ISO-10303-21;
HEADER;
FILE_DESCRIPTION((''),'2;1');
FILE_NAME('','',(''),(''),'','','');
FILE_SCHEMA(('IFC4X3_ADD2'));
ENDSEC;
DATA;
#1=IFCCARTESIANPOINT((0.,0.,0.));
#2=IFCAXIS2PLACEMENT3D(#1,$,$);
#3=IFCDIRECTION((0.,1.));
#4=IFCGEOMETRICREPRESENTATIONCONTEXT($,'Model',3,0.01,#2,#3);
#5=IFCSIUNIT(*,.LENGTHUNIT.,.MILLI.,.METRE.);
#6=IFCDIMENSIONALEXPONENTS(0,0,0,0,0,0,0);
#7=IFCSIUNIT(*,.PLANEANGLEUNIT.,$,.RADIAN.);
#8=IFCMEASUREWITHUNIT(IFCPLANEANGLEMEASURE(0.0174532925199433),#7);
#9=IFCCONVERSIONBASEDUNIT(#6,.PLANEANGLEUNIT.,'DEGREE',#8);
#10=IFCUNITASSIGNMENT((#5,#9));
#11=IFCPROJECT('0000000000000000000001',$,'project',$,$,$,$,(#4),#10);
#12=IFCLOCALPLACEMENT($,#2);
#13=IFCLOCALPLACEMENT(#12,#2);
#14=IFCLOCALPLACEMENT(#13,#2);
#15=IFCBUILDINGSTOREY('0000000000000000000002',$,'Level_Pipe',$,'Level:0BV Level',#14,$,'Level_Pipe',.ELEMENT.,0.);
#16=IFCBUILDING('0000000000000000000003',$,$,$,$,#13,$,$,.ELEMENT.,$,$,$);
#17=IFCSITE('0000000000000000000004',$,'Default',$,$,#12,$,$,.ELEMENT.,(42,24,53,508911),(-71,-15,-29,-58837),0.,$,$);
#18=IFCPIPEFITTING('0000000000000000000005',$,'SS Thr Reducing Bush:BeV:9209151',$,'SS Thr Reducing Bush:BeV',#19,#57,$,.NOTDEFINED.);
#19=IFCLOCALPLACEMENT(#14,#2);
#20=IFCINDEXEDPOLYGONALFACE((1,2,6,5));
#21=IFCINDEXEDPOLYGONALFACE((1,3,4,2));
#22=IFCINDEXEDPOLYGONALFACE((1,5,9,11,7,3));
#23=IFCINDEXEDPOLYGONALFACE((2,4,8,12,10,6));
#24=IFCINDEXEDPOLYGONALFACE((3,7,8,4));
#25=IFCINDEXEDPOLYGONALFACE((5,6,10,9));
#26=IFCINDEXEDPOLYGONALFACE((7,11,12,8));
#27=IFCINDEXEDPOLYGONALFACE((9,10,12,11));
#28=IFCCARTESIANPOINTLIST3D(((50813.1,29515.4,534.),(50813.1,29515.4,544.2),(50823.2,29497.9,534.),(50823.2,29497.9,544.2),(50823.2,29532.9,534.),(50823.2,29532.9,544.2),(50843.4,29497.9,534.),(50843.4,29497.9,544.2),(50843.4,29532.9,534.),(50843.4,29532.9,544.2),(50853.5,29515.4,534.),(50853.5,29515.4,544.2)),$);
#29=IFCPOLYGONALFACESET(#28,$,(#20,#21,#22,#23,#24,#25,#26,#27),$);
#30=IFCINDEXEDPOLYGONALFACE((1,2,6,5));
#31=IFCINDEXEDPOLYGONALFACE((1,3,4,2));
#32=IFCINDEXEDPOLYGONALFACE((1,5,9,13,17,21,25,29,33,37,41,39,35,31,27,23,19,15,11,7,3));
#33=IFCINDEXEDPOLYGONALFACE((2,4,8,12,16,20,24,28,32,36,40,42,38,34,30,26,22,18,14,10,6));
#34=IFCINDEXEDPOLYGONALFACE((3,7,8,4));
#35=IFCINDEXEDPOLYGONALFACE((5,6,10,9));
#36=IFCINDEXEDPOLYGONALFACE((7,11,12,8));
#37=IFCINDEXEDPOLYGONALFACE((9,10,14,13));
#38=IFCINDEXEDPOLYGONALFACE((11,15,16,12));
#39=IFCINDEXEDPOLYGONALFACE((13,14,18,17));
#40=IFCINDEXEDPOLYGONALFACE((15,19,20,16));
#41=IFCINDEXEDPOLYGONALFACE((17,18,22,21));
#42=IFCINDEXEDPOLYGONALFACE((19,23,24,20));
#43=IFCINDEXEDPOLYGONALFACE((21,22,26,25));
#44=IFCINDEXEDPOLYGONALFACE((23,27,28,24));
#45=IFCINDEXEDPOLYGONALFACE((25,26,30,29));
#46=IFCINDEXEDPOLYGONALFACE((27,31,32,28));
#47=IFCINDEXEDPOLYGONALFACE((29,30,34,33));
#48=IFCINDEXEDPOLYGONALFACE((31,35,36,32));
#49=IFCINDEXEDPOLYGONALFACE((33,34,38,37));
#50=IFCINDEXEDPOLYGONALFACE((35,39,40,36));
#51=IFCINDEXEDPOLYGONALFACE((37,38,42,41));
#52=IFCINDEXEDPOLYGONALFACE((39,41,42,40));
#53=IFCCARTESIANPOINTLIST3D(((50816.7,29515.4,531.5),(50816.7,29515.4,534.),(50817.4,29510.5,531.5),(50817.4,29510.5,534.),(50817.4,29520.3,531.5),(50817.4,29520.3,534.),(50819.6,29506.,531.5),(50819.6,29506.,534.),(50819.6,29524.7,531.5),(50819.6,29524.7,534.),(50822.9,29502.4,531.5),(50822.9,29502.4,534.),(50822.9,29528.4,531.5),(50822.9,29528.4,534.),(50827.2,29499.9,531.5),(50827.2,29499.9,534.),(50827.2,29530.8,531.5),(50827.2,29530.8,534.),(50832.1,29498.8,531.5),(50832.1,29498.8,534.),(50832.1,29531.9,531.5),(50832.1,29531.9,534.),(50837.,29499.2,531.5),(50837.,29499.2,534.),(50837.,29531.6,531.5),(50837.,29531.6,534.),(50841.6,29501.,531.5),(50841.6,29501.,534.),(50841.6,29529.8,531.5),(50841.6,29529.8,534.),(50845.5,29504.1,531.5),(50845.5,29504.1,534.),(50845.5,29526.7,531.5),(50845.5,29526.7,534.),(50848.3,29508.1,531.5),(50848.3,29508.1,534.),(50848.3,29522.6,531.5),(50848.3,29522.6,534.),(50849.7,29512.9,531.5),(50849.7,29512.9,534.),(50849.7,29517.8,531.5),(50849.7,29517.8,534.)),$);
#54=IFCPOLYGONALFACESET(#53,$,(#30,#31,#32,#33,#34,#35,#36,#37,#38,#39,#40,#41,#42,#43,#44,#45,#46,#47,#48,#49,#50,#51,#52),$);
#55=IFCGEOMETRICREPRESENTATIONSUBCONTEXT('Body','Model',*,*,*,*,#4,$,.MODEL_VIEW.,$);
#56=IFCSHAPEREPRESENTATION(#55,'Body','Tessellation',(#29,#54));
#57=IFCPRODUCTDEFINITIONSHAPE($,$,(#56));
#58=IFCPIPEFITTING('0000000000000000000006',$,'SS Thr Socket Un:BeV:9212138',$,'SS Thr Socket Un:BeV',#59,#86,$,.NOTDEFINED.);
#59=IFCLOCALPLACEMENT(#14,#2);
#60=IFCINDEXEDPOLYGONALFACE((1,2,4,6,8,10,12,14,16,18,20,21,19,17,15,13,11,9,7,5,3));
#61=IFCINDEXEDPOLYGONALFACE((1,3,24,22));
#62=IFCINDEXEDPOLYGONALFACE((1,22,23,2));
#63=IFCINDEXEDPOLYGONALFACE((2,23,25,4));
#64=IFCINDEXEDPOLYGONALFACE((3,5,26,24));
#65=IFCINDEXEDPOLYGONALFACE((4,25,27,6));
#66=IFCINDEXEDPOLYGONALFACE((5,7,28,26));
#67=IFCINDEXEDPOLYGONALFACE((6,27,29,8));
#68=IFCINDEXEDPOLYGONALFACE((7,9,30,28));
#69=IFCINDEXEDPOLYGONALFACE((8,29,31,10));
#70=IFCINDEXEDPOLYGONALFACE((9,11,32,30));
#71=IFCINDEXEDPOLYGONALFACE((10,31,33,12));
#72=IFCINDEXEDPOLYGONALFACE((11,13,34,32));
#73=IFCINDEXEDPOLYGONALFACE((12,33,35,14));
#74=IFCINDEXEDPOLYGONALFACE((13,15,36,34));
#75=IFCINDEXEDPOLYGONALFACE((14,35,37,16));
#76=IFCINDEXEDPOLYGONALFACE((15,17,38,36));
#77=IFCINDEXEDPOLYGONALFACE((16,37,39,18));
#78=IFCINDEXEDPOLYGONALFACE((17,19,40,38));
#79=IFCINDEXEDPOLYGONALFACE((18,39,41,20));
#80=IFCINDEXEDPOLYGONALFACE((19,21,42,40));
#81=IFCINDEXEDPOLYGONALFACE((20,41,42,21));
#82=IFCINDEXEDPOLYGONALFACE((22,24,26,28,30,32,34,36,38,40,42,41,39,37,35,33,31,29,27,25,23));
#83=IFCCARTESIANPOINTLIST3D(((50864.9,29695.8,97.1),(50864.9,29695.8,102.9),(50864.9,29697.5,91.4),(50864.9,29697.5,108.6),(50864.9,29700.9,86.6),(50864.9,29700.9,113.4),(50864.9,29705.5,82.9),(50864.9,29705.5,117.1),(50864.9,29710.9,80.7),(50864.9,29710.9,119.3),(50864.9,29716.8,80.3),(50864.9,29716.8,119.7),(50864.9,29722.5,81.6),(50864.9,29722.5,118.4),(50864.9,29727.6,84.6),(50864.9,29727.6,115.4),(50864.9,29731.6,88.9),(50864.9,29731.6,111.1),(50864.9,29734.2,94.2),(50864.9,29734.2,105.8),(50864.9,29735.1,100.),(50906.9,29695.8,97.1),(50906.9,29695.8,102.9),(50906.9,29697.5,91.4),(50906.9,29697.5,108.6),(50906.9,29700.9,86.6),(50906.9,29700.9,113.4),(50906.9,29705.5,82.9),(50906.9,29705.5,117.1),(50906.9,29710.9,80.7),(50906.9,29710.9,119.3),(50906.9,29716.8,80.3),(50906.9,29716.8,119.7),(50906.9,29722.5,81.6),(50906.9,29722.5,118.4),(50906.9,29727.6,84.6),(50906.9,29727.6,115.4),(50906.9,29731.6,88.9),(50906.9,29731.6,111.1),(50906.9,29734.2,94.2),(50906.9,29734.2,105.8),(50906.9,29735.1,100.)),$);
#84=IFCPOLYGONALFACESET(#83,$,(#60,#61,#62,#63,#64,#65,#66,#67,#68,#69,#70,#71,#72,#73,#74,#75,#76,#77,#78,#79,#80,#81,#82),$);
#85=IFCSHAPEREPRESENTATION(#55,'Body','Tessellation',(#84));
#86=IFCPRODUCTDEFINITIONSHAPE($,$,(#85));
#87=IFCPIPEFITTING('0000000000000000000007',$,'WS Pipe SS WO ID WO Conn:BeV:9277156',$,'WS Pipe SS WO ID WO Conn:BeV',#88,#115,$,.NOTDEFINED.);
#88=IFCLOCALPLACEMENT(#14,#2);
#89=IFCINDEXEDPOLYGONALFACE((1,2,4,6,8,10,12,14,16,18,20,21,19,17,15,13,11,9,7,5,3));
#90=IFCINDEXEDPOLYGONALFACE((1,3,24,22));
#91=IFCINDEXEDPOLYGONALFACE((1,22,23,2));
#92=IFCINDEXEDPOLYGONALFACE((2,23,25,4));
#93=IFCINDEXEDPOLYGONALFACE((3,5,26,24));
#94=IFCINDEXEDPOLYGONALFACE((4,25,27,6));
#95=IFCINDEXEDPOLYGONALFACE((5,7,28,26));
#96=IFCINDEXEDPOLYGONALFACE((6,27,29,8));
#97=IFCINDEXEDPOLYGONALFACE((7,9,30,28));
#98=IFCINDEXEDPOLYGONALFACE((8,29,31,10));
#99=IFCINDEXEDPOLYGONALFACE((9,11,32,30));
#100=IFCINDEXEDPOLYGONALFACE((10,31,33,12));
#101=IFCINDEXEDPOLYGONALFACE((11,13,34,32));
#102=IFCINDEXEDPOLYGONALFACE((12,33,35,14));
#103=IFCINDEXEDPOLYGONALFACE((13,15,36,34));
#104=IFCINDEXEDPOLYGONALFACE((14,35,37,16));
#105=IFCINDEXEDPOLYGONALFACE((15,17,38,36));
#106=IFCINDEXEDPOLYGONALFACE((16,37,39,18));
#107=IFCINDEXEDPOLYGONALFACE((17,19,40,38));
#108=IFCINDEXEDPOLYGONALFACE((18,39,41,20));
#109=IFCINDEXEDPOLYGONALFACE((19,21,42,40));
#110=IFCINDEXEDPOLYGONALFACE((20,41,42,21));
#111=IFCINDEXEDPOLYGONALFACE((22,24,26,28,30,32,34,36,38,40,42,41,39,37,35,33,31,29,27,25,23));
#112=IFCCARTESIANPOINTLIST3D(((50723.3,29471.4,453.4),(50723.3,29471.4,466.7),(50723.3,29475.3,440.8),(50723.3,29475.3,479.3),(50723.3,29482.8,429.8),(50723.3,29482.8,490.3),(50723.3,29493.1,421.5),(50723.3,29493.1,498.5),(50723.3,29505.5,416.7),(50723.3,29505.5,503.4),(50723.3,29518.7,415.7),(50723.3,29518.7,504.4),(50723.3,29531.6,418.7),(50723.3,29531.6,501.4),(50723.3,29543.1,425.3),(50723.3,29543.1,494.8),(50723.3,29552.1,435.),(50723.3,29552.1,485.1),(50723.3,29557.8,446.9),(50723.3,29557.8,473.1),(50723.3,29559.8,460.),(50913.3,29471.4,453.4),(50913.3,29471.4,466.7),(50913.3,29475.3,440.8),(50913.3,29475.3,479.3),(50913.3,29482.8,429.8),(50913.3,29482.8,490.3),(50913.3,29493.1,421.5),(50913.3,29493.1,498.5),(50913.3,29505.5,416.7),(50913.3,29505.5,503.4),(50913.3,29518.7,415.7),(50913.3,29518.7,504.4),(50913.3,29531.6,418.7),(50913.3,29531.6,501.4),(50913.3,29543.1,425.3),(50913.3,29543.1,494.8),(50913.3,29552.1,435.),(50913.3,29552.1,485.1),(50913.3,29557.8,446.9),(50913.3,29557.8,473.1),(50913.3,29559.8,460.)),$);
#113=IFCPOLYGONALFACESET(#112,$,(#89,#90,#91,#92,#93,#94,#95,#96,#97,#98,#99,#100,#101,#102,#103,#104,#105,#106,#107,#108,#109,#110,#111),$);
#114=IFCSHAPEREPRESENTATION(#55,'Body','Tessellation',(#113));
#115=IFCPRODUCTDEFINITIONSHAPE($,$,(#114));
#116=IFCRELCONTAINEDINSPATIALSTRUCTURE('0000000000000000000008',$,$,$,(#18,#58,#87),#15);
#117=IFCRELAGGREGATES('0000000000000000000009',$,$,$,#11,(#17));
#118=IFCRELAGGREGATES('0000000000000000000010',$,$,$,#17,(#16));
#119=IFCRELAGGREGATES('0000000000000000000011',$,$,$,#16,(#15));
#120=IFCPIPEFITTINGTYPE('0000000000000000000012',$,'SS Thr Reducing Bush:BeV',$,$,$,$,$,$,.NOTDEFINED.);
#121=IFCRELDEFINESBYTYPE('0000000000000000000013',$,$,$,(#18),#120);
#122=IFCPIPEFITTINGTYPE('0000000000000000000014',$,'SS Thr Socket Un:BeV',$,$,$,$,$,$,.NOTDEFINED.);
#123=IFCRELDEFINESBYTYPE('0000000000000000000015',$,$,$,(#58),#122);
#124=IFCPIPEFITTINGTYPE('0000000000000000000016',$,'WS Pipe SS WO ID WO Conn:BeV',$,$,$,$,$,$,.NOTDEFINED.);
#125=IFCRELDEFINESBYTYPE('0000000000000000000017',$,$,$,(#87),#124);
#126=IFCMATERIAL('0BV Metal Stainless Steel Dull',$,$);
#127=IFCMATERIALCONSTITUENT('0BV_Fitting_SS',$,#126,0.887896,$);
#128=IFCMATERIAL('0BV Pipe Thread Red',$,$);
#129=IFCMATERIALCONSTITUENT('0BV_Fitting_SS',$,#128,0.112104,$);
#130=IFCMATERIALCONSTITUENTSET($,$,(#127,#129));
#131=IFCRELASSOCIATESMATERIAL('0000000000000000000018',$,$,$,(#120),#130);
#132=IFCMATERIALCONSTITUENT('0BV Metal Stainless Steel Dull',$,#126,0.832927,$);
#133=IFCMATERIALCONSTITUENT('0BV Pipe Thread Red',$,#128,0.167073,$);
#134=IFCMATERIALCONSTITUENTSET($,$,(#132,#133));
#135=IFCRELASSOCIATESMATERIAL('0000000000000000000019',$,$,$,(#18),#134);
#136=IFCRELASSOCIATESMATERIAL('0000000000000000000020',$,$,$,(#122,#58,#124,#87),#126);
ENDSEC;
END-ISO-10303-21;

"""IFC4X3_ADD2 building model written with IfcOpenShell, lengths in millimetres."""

from ifc_helpers import new_model, entity, si_unit, converted_unit, direction, frame, frame_2d, origin, place, context, subcontext, project, spatial, polyline, circle, outline, extrude, source, transform, mapped, material, constituent, constituent_set, type_object, type_shapes, element, save


model = new_model("IFC4X3_ADD2")

# Units and contexts
model_context = context("Model", 3, precision=0.01, world=origin(), true_north=direction((0.0, 1.0)))
body_context = subcontext(model_context, "Body", "Model", "MODEL_VIEW")
ifc_project = project(units=[si_unit("LENGTHUNIT", "METRE", prefix="MILLI"), converted_unit("PLANEANGLEUNIT", "DEGREE", entity("IfcPlaneAngleMeasure", 0.0174532925199433), si_unit("PLANEANGLEUNIT", "RADIAN"), dimensions=[0, 0, 0, 0, 0, 0, 0])], contexts=[model_context])

# Site, building, storey
site_placement = place(None, origin())
site = spatial("IfcSite", under=ifc_project, at=site_placement, Name="Default", CompositionType="ELEMENT", RefLatitude=(42, 24, 53, 508911), RefLongitude=(-71, -15, -29, -58837), RefElevation=0.0)
building_placement = place(site_placement, origin())
building = spatial("IfcBuilding", under=site, at=building_placement, CompositionType="ELEMENT")
storey_placement = place(building_placement, origin())
storey = spatial("IfcBuildingStorey", under=building, at=storey_placement, Name="Level_Pipe", ObjectType="Level:0BV Level", LongName="Level_Pipe", CompositionType="ELEMENT", Elevation=0.0)

# Pipe fitting
ifc_material_1 = material(Name="0BV Metal Stainless Steel Dull")
ifc_material_2 = material(Name="0BV Pipe Thread Red")
ifc_constituent_1 = constituent(ifc_material_1, Name="0BV Metal Stainless Steel Dull", fraction=0.832927)
ifc_constituent_2 = constituent(ifc_material_2, Name="0BV Pipe Thread Red", fraction=0.167073)
ifc_constituent_set_1 = constituent_set(constituents=[ifc_constituent_1, ifc_constituent_2])
ifc_constituent_3 = constituent(ifc_material_1, Name="0BV_Fitting_SS", fraction=0.887896)
ifc_constituent_4 = constituent(ifc_material_2, Name="0BV_Fitting_SS", fraction=0.112104)
ifc_constituent_set_2 = constituent_set(constituents=[ifc_constituent_3, ifc_constituent_4])
pipe_fitting_type_1 = type_object("IfcPipeFittingType", Name="SS Thr Reducing Bush:BeV", PredefinedType="NOTDEFINED", material=ifc_constituent_set_2)
shared_shape_1 = source(origin(), body_context, "Body", "SweptSolid", [
    extrude(outline(polyline([(-10.1, -17.5), (10.1, -17.5), (20.2, 0.0), (10.1, 17.5), (-10.1, 17.5), (-20.2, 0.0), (-10.1, -17.5)])), frame((2.5, 20.2, 18.2), z_axis=(1.0, 0.0, 0.0), x_axis=(0.0, -0.5, -0.866025)), (0.0, 0.0, 1.0), 10.2),
    extrude(circle(Radius=16.6, at=frame_2d((0.0, 0.0), x_axis=(1.0, 0.0))), frame((0.0, 20.2, 18.2), z_axis=(1.0, 0.0, 0.0), x_axis=(0.0, 1.0, 0.0)), (0.0, 0.0, 1.0), 2.5),
])
type_shapes(pipe_fitting_type_1, [shared_shape_1])
pipe_fitting_1_placement = place(storey_placement, frame((50853.5, 29533.6, 531.5), z_axis=(0.0, -1.0, 0.0), x_axis=(0.0, 0.0, 1.0)))
element("IfcPipeFitting", 1, at=pipe_fitting_1_placement, inside=storey, type_object=pipe_fitting_type_1, material=ifc_constituent_set_1, Name="SS Thr Reducing Bush:BeV:9209151", ObjectType="SS Thr Reducing Bush:BeV", PredefinedType="NOTDEFINED", context=body_context, shape_type="MappedRepresentation", body=[
    mapped(shared_shape_1, transform((0.0, 0.0, 0.0), scale=1.0)),
])

# Pipe fittings
pipe_fitting_type_2 = type_object("IfcPipeFittingType", Name="SS Thr Socket Un:BeV", PredefinedType="NOTDEFINED", material=ifc_material_1)
shared_shape_2 = source(origin(), body_context, "Body", "SweptSolid", [
    extrude(circle(Radius=19.8, at=frame_2d((0.0, 0.0), x_axis=(1.0, 0.0))), frame((-21.0, 0.0, 0.0), z_axis=(1.0, 0.0, 0.0), x_axis=(0.0, 1.0, 0.0)), (0.0, 0.0, 1.0), 42.0),
])
type_shapes(pipe_fitting_type_2, [shared_shape_2])
pipe_fitting_2_placement = place(storey_placement, frame((50885.9, 29715.3, 100.0)))
element("IfcPipeFitting", 2, at=pipe_fitting_2_placement, inside=storey, type_object=pipe_fitting_type_2, material=ifc_material_1, Name="SS Thr Socket Un:BeV:9212138", ObjectType="SS Thr Socket Un:BeV", PredefinedType="NOTDEFINED", context=body_context, shape_type="MappedRepresentation", body=[
    mapped(shared_shape_2, transform((0.0, 0.0, 0.0), scale=1.0)),
])
pipe_fitting_type_3 = type_object("IfcPipeFittingType", Name="WS Pipe SS WO ID WO Conn:BeV", PredefinedType="NOTDEFINED", material=ifc_material_1)
shared_shape_3 = source(origin(), body_context, "Body", "SweptSolid", [
    extrude(circle(Radius=44.5, at=frame_2d((0.0, 0.0), x_axis=(1.0, 0.0))), frame((-95.0, 0.0, 0.0), z_axis=(1.0, 0.0, 0.0), x_axis=(0.0, 1.0, 0.0)), (0.0, 0.0, 1.0), 190.0),
])
type_shapes(pipe_fitting_type_3, [shared_shape_3])
pipe_fitting_3_placement = place(storey_placement, frame((50818.3, 29515.4, 460.0)))
element("IfcPipeFitting", 3, at=pipe_fitting_3_placement, inside=storey, type_object=pipe_fitting_type_3, material=ifc_material_1, Name="WS Pipe SS WO ID WO Conn:BeV:9277156", ObjectType="WS Pipe SS WO ID WO Conn:BeV", PredefinedType="NOTDEFINED", context=body_context, shape_type="MappedRepresentation", body=[
    mapped(shared_shape_3, transform((0.0, 0.0, 0.0), scale=1.0)),
])

save(model, "model.ifc")
